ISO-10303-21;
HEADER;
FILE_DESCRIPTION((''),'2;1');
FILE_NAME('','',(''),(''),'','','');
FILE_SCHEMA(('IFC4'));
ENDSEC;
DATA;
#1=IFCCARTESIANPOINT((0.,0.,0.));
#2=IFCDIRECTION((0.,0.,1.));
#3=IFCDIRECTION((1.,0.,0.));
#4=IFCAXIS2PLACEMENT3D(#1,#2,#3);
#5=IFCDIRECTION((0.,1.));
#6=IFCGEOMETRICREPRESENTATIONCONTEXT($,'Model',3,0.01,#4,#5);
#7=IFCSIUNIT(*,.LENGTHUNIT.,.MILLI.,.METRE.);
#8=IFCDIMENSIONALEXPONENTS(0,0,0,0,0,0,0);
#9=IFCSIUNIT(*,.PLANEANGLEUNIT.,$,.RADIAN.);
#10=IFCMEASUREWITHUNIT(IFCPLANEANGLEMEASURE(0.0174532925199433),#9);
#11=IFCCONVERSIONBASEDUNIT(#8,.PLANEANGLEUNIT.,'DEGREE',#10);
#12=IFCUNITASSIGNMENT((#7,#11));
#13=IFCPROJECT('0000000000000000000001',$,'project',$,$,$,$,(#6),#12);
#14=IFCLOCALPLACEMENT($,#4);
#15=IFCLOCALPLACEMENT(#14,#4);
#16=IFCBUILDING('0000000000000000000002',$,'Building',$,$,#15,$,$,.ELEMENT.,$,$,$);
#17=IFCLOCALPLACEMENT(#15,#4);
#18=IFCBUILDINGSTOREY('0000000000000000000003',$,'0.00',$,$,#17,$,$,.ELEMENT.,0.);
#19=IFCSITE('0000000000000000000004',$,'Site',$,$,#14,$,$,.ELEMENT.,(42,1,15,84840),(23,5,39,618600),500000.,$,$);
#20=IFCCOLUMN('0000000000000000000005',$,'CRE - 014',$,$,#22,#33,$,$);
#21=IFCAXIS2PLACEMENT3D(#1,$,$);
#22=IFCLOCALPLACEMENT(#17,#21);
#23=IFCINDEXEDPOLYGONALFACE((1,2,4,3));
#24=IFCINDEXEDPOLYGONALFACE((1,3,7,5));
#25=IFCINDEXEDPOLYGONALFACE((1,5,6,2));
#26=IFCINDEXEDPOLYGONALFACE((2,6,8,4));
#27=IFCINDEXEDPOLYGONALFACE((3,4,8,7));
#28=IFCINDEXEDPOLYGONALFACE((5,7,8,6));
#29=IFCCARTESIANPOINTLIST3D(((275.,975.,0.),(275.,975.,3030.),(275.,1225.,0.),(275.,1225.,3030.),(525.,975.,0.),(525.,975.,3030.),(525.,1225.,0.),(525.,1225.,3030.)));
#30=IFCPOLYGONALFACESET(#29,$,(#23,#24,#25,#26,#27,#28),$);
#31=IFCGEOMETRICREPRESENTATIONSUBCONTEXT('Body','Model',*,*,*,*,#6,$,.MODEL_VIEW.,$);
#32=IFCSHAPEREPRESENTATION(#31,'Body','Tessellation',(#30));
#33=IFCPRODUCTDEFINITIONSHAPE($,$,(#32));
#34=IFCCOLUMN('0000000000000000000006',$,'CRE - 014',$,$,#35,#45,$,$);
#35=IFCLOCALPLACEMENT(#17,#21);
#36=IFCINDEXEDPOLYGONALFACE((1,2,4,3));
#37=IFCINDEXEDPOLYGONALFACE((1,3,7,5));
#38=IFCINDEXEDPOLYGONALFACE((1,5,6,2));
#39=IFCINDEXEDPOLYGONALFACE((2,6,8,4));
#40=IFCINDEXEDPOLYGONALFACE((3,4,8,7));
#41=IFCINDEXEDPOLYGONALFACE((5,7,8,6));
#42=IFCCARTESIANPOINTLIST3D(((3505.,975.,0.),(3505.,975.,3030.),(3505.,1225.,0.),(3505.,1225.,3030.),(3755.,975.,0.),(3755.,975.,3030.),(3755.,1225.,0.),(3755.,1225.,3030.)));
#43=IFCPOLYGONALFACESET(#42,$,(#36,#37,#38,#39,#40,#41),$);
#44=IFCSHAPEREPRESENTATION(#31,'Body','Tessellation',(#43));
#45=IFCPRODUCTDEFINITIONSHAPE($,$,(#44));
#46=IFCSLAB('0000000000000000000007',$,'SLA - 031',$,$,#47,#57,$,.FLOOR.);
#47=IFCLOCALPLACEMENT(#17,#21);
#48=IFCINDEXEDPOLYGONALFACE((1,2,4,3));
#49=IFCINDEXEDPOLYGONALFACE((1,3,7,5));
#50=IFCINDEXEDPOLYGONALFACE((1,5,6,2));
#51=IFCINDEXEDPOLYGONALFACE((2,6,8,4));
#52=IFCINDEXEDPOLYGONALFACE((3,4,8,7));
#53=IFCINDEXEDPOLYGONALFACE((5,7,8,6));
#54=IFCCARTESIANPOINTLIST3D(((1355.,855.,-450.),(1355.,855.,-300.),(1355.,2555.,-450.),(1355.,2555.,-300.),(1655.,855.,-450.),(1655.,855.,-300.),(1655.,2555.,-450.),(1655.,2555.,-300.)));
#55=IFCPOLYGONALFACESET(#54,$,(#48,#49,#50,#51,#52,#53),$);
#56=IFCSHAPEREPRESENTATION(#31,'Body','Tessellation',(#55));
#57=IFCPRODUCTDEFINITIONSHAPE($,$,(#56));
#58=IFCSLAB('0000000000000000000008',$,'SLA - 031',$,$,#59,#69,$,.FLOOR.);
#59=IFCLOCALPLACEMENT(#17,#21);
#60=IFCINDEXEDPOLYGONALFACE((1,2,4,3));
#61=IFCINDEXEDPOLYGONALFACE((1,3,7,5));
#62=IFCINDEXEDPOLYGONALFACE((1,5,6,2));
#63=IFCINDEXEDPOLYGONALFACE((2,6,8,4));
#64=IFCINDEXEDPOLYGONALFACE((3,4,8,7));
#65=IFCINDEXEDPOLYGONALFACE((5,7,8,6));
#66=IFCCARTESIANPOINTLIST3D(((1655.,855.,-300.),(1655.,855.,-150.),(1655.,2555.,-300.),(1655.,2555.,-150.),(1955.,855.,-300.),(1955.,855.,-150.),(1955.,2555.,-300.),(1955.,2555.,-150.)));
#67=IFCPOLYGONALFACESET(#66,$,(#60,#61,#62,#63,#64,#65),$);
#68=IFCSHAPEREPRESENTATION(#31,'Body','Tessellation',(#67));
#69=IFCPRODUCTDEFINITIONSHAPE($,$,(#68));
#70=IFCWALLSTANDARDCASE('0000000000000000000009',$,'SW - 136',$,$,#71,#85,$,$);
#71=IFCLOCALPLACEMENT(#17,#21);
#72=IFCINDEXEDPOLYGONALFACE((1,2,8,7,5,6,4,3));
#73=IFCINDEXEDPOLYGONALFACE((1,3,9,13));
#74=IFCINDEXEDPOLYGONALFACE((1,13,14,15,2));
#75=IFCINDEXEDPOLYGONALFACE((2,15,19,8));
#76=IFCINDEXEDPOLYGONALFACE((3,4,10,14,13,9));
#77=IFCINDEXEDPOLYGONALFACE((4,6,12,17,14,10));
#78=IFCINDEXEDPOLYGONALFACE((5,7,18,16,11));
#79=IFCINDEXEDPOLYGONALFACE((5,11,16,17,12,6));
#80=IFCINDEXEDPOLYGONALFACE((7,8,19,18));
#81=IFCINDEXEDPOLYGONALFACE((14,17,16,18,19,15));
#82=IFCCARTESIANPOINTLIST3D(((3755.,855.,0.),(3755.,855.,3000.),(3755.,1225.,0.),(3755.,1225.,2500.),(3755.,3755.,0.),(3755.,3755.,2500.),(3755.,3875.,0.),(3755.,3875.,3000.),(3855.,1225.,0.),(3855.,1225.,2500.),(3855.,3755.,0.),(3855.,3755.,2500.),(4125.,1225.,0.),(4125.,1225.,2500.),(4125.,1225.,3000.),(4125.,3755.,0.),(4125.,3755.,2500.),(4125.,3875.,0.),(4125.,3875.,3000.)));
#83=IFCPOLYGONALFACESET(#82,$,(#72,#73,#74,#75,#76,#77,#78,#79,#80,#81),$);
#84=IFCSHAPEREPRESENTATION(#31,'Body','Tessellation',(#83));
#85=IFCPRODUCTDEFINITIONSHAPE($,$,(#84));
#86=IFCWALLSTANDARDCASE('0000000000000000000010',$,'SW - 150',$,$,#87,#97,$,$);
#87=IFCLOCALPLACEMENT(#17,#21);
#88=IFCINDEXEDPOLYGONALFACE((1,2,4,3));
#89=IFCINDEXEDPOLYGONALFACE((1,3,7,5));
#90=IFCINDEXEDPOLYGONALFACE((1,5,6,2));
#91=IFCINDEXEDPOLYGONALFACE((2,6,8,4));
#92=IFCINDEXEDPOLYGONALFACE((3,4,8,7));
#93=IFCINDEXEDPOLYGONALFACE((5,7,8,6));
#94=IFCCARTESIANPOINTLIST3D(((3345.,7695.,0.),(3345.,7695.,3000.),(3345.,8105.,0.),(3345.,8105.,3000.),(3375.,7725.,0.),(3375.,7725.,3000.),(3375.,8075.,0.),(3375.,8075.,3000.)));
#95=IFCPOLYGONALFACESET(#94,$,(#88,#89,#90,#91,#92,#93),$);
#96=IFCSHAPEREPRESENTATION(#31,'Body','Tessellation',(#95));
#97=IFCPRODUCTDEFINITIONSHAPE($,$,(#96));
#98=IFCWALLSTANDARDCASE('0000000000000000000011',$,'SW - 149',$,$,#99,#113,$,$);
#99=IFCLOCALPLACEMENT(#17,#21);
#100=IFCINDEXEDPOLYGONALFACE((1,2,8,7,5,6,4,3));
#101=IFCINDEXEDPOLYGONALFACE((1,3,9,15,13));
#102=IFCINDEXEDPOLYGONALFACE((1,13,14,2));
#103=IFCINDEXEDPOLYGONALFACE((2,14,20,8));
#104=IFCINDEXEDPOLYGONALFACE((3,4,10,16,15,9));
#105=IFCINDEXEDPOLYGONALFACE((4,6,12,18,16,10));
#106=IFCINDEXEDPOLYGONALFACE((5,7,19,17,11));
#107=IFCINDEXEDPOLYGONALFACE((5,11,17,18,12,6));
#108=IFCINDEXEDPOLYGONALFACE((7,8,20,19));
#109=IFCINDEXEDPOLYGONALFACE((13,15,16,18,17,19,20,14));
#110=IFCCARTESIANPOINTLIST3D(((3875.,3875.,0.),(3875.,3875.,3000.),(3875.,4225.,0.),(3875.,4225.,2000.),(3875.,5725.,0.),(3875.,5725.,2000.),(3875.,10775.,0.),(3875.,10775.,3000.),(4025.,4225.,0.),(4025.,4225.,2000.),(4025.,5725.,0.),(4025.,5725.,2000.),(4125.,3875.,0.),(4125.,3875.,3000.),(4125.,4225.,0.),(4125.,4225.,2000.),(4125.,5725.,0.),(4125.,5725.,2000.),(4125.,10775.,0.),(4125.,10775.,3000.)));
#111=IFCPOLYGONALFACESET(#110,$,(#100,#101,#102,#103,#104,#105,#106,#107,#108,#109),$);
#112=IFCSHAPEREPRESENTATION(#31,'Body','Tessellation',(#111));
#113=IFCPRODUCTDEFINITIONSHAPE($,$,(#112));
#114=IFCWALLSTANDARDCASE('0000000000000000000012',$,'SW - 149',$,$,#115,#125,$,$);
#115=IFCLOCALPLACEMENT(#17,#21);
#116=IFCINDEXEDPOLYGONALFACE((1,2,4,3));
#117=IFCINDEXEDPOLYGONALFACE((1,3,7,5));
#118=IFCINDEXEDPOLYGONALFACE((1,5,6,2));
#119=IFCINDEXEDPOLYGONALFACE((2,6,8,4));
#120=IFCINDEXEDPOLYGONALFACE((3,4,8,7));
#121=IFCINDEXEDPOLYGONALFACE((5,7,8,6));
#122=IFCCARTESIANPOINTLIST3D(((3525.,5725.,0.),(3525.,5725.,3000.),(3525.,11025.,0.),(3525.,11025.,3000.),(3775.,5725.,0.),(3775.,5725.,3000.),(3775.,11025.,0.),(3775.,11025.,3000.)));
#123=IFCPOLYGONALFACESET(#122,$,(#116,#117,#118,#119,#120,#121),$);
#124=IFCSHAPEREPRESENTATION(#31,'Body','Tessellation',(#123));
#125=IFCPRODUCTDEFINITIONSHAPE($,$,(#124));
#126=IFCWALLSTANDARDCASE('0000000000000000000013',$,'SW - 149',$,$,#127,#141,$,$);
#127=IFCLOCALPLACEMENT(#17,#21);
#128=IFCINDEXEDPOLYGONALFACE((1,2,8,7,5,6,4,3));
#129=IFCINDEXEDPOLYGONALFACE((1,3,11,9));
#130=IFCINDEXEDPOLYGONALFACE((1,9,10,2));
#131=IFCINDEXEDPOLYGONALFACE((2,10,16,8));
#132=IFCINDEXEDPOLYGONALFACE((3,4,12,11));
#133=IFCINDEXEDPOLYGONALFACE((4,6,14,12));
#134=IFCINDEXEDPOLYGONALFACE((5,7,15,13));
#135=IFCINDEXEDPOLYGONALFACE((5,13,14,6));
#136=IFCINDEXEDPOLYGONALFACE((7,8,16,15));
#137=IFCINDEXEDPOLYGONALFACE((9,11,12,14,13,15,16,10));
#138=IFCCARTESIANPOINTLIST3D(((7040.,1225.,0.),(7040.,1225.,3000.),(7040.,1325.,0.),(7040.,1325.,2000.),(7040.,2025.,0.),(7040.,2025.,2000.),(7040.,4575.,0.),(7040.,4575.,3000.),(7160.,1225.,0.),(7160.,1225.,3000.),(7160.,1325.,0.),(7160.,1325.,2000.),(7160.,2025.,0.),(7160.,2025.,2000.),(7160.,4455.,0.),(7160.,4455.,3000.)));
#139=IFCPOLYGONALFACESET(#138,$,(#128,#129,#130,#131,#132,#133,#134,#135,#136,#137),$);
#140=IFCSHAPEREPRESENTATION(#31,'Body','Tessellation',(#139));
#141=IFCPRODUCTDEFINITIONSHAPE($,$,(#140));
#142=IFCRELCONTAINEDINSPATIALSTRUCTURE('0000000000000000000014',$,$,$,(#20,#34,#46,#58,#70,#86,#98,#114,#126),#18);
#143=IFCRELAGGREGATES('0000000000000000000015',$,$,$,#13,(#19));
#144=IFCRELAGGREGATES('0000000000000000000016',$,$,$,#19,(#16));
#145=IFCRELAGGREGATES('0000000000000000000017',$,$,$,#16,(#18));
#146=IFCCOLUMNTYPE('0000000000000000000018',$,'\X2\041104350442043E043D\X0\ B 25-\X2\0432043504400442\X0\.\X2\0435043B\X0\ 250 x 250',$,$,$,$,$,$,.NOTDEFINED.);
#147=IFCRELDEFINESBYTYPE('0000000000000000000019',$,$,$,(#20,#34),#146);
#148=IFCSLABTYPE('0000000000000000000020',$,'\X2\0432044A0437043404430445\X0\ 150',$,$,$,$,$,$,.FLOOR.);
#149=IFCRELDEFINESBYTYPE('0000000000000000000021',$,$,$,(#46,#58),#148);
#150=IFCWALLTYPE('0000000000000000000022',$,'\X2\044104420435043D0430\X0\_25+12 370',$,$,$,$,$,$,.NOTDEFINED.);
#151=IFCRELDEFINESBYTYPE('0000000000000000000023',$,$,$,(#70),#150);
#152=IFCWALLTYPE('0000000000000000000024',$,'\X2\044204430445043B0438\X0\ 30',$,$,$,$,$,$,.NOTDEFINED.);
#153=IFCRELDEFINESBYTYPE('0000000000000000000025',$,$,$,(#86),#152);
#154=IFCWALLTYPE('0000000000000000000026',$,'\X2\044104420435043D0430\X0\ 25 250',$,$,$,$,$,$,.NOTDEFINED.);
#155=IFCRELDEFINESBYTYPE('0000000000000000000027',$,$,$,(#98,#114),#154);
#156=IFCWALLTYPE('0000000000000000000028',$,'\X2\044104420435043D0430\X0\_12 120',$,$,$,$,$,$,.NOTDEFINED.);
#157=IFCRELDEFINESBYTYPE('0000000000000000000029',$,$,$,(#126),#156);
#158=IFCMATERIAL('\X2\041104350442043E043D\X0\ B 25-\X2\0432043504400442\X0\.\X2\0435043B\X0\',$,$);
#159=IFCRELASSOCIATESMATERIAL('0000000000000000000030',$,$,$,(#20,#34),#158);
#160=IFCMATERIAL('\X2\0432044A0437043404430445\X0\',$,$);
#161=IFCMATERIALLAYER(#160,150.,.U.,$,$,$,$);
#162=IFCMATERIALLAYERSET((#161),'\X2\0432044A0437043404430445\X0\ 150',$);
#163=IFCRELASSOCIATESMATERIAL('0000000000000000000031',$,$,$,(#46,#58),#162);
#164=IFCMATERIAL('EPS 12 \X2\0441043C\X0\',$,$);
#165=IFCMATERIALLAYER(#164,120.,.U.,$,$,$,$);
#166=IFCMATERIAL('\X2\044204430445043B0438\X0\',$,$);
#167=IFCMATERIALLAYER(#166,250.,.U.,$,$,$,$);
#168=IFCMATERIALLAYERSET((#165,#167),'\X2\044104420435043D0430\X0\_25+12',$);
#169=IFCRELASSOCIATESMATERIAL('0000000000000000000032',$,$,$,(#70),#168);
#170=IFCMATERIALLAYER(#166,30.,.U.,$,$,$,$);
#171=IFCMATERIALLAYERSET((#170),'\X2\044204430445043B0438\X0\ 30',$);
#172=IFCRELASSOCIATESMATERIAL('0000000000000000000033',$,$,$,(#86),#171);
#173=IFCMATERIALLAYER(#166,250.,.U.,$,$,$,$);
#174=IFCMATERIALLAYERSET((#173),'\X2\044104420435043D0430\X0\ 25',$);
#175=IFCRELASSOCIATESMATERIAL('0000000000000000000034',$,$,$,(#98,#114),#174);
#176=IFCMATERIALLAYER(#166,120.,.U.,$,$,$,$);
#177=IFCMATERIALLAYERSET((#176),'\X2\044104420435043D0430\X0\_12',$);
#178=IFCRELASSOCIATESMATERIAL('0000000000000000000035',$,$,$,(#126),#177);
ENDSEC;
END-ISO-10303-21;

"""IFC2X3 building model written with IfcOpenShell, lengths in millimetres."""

from ifc_helpers import new_model, entity, si_unit, converted_unit, direction, frame, origin_with_axes, origin_2d_with_axis, place, context, subcontext, project, spatial, polyline, rectangle, outline, extrude, material, layer, layer_set, layer_usage, type_object, element, save


model = new_model("IFC2X3")

# Units and contexts
model_context = context("Model", 3, precision=0.01, world=origin_with_axes(), true_north=direction((0.0, 1.0)))
body_context = subcontext(model_context, "Body", "Model", "MODEL_VIEW")
ifc_project = project(units=[si_unit("LENGTHUNIT", "METRE", prefix="MILLI"), converted_unit("PLANEANGLEUNIT", "DEGREE", entity("IfcPlaneAngleMeasure", 0.0174532925199433), si_unit("PLANEANGLEUNIT", "RADIAN"), dimensions=[0, 0, 0, 0, 0, 0, 0])], contexts=[model_context])

# Site, building, storey
site_placement = place(None, origin_with_axes())
site = spatial("IfcSite", under=ifc_project, at=site_placement, Name="Site", CompositionType="ELEMENT", RefLatitude=(42, 1, 15, 84840), RefLongitude=(23, 5, 39, 618600), RefElevation=500000.0)
building_placement = place(site_placement, origin_with_axes())
building = spatial("IfcBuilding", under=site, at=building_placement, Name="Building", CompositionType="ELEMENT")
storey_placement = place(building_placement, origin_with_axes())
storey = spatial("IfcBuildingStorey", under=building, at=storey_placement, Name="0.00", CompositionType="ELEMENT", Elevation=0.0)

# Columns
ifc_material_1 = material(Name="Бетон B 25-верт.ел")
column_type = type_object("IfcColumnType", Name="Бетон B 25-верт.ел 250 x 250", PredefinedType="NOTDEFINED")
for number, where, z_axis, x_axis, name in (
    (1, (400.0, 1100.0, 0.0), (0.0, 0.0, 1.0), (1.0, 0.0, 0.0), "CRE - 014"),
    (2, (3630.0, 1100.0, 0.0), (0.0, 0.0, 1.0), (1.0, 0.0, 0.0), "CRE - 014"),
):
    element("IfcColumn", number, at=place(storey_placement, frame(where, z_axis=z_axis, x_axis=x_axis)), inside=storey, type_object=column_type, material=ifc_material_1, Name=name, context=body_context, shape_type="SweptSolid", body=[
        extrude(rectangle(XDim=250.0, YDim=250.0, at=origin_2d_with_axis()), origin_with_axes(), (0.0, 0.0, 1.0), 3030.0),
    ])

# Slabs
ifc_material_2 = material(Name="въздух")
ifc_layer_1 = layer(ifc_material_2, 150.0, ventilated="UNKNOWN")
ifc_layer_set_1 = layer_set([ifc_layer_1], Name="въздух 150")
ifc_layer_usage_1 = layer_usage(ifc_layer_set_1, "AXIS3", "NEGATIVE", 150.0)
slab_type = type_object("IfcSlabType", Name="въздух 150", PredefinedType="FLOOR")
slab_1_placement = place(storey_placement, frame((1355.0, 855.0, -300.0), z_axis=(0.0, 0.0, 1.0), x_axis=(1.0, 0.0, 0.0)))
element("IfcSlab", 3, at=slab_1_placement, inside=storey, type_object=slab_type, material=ifc_layer_usage_1, Name="SLA - 031", PredefinedType="FLOOR", context=body_context, shape_type="SweptSolid", body=[
    extrude(outline(polyline([(0.0, 0.0), (300.0, 0.0), (300.0, 1700.0), (0.0, 1700.0), (0.0, 0.0)])), frame((0.0, 0.0, -150.0), z_axis=(0.0, 0.0, 1.0), x_axis=(1.0, 0.0, 0.0)), (0.0, 0.0, 1.0), 150.0),
])
ifc_layer_usage_2 = layer_usage(ifc_layer_set_1, "AXIS3", "NEGATIVE", 150.0)
slab_2_placement = place(storey_placement, frame((1655.0, 855.0, -150.0), z_axis=(0.0, 0.0, 1.0), x_axis=(1.0, 0.0, 0.0)))
element("IfcSlab", 4, at=slab_2_placement, inside=storey, type_object=slab_type, material=ifc_layer_usage_2, Name="SLA - 031", PredefinedType="FLOOR", context=body_context, shape_type="SweptSolid", body=[
    extrude(outline(polyline([(0.0, 0.0), (300.0, 0.0), (300.0, 1700.0), (0.0, 1700.0), (0.0, 0.0)])), frame((0.0, 0.0, -150.0), z_axis=(0.0, 0.0, 1.0), x_axis=(1.0, 0.0, 0.0)), (0.0, 0.0, 1.0), 150.0),
])

# Shared definitions
ifc_material_3 = material(Name="EPS 12 см")
ifc_layer_2 = layer(ifc_material_3, 120.0, ventilated="UNKNOWN")
ifc_material_4 = material(Name="тухли")
ifc_layer_3 = layer(ifc_material_4, 250.0, ventilated="UNKNOWN")
ifc_layer_set_2 = layer_set([ifc_layer_2, ifc_layer_3], Name="стена_25+12")
wall_type_1 = type_object("IfcWallType", Name="стена_25+12 370", PredefinedType="NOTDEFINED")

# Wall, opening
ifc_layer_usage_3 = layer_usage(ifc_layer_set_2, "AXIS2", "POSITIVE", -120.0)
wall_1_placement = place(storey_placement, frame((3875.0, 3875.0, 0.0), z_axis=(0.0, 0.0, 1.0), x_axis=(0.0, -1.0, 0.0)))
wall_1 = element("IfcWallStandardCase", 5, at=wall_1_placement, inside=storey, type_object=wall_type_1, material=ifc_layer_usage_3, Name="SW - 136", context=body_context, shape_type="SweptSolid", body=[
    extrude(outline(polyline([(0.0, -120.0), (3020.0, -120.0), (2650.0, 250.0), (0.0, 250.0), (0.0, -120.0)])), origin_with_axes(), (0.0, 0.0, 1.0), 3000.0),
])
opening_1_placement = place(wall_1_placement, frame((1385.0, 0.0, 0.0), z_axis=(0.0, 0.0, 1.0), x_axis=(1.0, 0.0, 0.0)))
element("IfcOpeningElement", 6, at=opening_1_placement, cuts=wall_1, context=body_context, shape_type="SweptSolid", body=[
    extrude(rectangle(XDim=2530.0, YDim=2500.0, at=origin_2d_with_axis()), frame((0.0, -20.0, 1250.0), z_axis=(0.0, 1.0, 0.0), x_axis=(1.0, 0.0, 0.0)), (0.0, 0.0, 1.0), 640.0),
    extrude(rectangle(XDim=2530.0, YDim=2500.0, at=origin_2d_with_axis()), frame((0.0, -20.0, 1250.0), z_axis=(0.0, -1.0, 0.0), x_axis=(1.0, 0.0, 0.0)), (0.0, 0.0, 1.0), 470.0),
])

# Wall
ifc_layer_4 = layer(ifc_material_4, 30.0, ventilated="UNKNOWN")
ifc_layer_set_3 = layer_set([ifc_layer_4], Name="тухли 30")
ifc_layer_usage_4 = layer_usage(ifc_layer_set_3, "AXIS2", "NEGATIVE", 0.0)
wall_type_2 = type_object("IfcWallType", Name="тухли 30", PredefinedType="NOTDEFINED")
wall_2_placement = place(storey_placement, frame((3345.0, 7695.0, 0.0), z_axis=(0.0, 0.0, 1.0), x_axis=(0.0, 1.0, 0.0)))
element("IfcWallStandardCase", 7, at=wall_2_placement, inside=storey, type_object=wall_type_2, material=ifc_layer_usage_4, Name="SW - 150", context=body_context, shape_type="SweptSolid", body=[
    extrude(outline(polyline([(30.0, -30.0), (380.0, -30.0), (410.0, 0.0), (0.0, 0.0), (30.0, -30.0)])), origin_with_axes(), (0.0, 0.0, 1.0), 3000.0),
])

# Wall, opening
ifc_layer_5 = layer(ifc_material_4, 250.0, ventilated="UNKNOWN")
ifc_layer_set_4 = layer_set([ifc_layer_5], Name="стена 25")
ifc_layer_usage_5 = layer_usage(ifc_layer_set_4, "AXIS2", "NEGATIVE", 0.0)
wall_type_3 = type_object("IfcWallType", Name="стена 25 250", PredefinedType="NOTDEFINED")
wall_3_placement = place(storey_placement, frame((3875.0, 3875.0, 0.0), z_axis=(0.0, 0.0, 1.0), x_axis=(0.0, 1.0, 0.0)))
wall_3 = element("IfcWallStandardCase", 8, at=wall_3_placement, inside=storey, type_object=wall_type_3, material=ifc_layer_usage_5, Name="SW - 149", context=body_context, shape_type="SweptSolid", body=[
    extrude(outline(polyline([(0.0, -250.0), (6900.0, -250.0), (6900.0, 0.0), (0.0, 0.0), (0.0, -250.0)])), origin_with_axes(), (0.0, 0.0, 1.0), 3000.0),
])
opening_2_placement = place(wall_3_placement, frame((1100.0, 0.0, 0.0), z_axis=(0.0, 0.0, 1.0), x_axis=(1.0, 0.0, 0.0)))
element("IfcOpeningElement", 9, at=opening_2_placement, cuts=wall_3, context=body_context, shape_type="SweptSolid", body=[
    extrude(rectangle(XDim=1500.0, YDim=2000.0, at=origin_2d_with_axis()), frame((0.0, -150.0, 1000.0), z_axis=(0.0, 1.0, 0.0), x_axis=(1.0, 0.0, 0.0)), (0.0, 0.0, 1.0), 400.0),
    extrude(rectangle(XDim=1500.0, YDim=2000.0, at=origin_2d_with_axis()), frame((0.0, -150.0, 1000.0), z_axis=(0.0, -1.0, 0.0), x_axis=(1.0, 0.0, 0.0)), (0.0, 0.0, 1.0), 350.0),
])

# Wall
ifc_layer_usage_6 = layer_usage(ifc_layer_set_4, "AXIS2", "NEGATIVE", 0.0)
wall_4_placement = place(storey_placement, frame((3525.0, 5725.0, 0.0), z_axis=(0.0, 0.0, 1.0), x_axis=(0.0, 1.0, 0.0)))
element("IfcWallStandardCase", 10, at=wall_4_placement, inside=storey, type_object=wall_type_3, material=ifc_layer_usage_6, Name="SW - 149", context=body_context, shape_type="SweptSolid", body=[
    extrude(outline(polyline([(0.0, -250.0), (5300.0, -250.0), (5300.0, 0.0), (0.0, 0.0), (0.0, -250.0)])), origin_with_axes(), (0.0, 0.0, 1.0), 3000.0),
])

# Wall, opening
ifc_layer_6 = layer(ifc_material_4, 120.0, ventilated="UNKNOWN")
ifc_layer_set_5 = layer_set([ifc_layer_6], Name="стена_12")
ifc_layer_usage_7 = layer_usage(ifc_layer_set_5, "AXIS2", "NEGATIVE", 0.0)
wall_type_4 = type_object("IfcWallType", Name="стена_12 120", PredefinedType="NOTDEFINED")
wall_5_placement = place(storey_placement, frame((7160.0, 4575.0, 0.0), z_axis=(0.0, 0.0, 1.0), x_axis=(0.0, -1.0, 0.0)))
wall_5 = element("IfcWallStandardCase", 11, at=wall_5_placement, inside=storey, type_object=wall_type_4, material=ifc_layer_usage_7, Name="SW - 149", context=body_context, shape_type="SweptSolid", body=[
    extrude(outline(polyline([(0.0, -120.0), (3350.0, -120.0), (3350.0, 0.0), (120.0, 0.0), (0.0, -120.0)])), origin_with_axes(), (0.0, 0.0, 1.0), 3000.0),
])
opening_3_placement = place(wall_5_placement, frame((2900.0, 0.0, 0.0), z_axis=(0.0, 0.0, 1.0), x_axis=(1.0, 0.0, 0.0)))
element("IfcOpeningElement", 12, at=opening_3_placement, cuts=wall_5, context=body_context, shape_type="SweptSolid", body=[
    extrude(rectangle(XDim=700.0, YDim=2000.0, at=origin_2d_with_axis()), frame((0.0, -120.0, 1000.0), z_axis=(0.0, 1.0, 0.0), x_axis=(1.0, 0.0, 0.0)), (0.0, 0.0, 1.0), 360.0),
])

save(model, "model.ifc")
